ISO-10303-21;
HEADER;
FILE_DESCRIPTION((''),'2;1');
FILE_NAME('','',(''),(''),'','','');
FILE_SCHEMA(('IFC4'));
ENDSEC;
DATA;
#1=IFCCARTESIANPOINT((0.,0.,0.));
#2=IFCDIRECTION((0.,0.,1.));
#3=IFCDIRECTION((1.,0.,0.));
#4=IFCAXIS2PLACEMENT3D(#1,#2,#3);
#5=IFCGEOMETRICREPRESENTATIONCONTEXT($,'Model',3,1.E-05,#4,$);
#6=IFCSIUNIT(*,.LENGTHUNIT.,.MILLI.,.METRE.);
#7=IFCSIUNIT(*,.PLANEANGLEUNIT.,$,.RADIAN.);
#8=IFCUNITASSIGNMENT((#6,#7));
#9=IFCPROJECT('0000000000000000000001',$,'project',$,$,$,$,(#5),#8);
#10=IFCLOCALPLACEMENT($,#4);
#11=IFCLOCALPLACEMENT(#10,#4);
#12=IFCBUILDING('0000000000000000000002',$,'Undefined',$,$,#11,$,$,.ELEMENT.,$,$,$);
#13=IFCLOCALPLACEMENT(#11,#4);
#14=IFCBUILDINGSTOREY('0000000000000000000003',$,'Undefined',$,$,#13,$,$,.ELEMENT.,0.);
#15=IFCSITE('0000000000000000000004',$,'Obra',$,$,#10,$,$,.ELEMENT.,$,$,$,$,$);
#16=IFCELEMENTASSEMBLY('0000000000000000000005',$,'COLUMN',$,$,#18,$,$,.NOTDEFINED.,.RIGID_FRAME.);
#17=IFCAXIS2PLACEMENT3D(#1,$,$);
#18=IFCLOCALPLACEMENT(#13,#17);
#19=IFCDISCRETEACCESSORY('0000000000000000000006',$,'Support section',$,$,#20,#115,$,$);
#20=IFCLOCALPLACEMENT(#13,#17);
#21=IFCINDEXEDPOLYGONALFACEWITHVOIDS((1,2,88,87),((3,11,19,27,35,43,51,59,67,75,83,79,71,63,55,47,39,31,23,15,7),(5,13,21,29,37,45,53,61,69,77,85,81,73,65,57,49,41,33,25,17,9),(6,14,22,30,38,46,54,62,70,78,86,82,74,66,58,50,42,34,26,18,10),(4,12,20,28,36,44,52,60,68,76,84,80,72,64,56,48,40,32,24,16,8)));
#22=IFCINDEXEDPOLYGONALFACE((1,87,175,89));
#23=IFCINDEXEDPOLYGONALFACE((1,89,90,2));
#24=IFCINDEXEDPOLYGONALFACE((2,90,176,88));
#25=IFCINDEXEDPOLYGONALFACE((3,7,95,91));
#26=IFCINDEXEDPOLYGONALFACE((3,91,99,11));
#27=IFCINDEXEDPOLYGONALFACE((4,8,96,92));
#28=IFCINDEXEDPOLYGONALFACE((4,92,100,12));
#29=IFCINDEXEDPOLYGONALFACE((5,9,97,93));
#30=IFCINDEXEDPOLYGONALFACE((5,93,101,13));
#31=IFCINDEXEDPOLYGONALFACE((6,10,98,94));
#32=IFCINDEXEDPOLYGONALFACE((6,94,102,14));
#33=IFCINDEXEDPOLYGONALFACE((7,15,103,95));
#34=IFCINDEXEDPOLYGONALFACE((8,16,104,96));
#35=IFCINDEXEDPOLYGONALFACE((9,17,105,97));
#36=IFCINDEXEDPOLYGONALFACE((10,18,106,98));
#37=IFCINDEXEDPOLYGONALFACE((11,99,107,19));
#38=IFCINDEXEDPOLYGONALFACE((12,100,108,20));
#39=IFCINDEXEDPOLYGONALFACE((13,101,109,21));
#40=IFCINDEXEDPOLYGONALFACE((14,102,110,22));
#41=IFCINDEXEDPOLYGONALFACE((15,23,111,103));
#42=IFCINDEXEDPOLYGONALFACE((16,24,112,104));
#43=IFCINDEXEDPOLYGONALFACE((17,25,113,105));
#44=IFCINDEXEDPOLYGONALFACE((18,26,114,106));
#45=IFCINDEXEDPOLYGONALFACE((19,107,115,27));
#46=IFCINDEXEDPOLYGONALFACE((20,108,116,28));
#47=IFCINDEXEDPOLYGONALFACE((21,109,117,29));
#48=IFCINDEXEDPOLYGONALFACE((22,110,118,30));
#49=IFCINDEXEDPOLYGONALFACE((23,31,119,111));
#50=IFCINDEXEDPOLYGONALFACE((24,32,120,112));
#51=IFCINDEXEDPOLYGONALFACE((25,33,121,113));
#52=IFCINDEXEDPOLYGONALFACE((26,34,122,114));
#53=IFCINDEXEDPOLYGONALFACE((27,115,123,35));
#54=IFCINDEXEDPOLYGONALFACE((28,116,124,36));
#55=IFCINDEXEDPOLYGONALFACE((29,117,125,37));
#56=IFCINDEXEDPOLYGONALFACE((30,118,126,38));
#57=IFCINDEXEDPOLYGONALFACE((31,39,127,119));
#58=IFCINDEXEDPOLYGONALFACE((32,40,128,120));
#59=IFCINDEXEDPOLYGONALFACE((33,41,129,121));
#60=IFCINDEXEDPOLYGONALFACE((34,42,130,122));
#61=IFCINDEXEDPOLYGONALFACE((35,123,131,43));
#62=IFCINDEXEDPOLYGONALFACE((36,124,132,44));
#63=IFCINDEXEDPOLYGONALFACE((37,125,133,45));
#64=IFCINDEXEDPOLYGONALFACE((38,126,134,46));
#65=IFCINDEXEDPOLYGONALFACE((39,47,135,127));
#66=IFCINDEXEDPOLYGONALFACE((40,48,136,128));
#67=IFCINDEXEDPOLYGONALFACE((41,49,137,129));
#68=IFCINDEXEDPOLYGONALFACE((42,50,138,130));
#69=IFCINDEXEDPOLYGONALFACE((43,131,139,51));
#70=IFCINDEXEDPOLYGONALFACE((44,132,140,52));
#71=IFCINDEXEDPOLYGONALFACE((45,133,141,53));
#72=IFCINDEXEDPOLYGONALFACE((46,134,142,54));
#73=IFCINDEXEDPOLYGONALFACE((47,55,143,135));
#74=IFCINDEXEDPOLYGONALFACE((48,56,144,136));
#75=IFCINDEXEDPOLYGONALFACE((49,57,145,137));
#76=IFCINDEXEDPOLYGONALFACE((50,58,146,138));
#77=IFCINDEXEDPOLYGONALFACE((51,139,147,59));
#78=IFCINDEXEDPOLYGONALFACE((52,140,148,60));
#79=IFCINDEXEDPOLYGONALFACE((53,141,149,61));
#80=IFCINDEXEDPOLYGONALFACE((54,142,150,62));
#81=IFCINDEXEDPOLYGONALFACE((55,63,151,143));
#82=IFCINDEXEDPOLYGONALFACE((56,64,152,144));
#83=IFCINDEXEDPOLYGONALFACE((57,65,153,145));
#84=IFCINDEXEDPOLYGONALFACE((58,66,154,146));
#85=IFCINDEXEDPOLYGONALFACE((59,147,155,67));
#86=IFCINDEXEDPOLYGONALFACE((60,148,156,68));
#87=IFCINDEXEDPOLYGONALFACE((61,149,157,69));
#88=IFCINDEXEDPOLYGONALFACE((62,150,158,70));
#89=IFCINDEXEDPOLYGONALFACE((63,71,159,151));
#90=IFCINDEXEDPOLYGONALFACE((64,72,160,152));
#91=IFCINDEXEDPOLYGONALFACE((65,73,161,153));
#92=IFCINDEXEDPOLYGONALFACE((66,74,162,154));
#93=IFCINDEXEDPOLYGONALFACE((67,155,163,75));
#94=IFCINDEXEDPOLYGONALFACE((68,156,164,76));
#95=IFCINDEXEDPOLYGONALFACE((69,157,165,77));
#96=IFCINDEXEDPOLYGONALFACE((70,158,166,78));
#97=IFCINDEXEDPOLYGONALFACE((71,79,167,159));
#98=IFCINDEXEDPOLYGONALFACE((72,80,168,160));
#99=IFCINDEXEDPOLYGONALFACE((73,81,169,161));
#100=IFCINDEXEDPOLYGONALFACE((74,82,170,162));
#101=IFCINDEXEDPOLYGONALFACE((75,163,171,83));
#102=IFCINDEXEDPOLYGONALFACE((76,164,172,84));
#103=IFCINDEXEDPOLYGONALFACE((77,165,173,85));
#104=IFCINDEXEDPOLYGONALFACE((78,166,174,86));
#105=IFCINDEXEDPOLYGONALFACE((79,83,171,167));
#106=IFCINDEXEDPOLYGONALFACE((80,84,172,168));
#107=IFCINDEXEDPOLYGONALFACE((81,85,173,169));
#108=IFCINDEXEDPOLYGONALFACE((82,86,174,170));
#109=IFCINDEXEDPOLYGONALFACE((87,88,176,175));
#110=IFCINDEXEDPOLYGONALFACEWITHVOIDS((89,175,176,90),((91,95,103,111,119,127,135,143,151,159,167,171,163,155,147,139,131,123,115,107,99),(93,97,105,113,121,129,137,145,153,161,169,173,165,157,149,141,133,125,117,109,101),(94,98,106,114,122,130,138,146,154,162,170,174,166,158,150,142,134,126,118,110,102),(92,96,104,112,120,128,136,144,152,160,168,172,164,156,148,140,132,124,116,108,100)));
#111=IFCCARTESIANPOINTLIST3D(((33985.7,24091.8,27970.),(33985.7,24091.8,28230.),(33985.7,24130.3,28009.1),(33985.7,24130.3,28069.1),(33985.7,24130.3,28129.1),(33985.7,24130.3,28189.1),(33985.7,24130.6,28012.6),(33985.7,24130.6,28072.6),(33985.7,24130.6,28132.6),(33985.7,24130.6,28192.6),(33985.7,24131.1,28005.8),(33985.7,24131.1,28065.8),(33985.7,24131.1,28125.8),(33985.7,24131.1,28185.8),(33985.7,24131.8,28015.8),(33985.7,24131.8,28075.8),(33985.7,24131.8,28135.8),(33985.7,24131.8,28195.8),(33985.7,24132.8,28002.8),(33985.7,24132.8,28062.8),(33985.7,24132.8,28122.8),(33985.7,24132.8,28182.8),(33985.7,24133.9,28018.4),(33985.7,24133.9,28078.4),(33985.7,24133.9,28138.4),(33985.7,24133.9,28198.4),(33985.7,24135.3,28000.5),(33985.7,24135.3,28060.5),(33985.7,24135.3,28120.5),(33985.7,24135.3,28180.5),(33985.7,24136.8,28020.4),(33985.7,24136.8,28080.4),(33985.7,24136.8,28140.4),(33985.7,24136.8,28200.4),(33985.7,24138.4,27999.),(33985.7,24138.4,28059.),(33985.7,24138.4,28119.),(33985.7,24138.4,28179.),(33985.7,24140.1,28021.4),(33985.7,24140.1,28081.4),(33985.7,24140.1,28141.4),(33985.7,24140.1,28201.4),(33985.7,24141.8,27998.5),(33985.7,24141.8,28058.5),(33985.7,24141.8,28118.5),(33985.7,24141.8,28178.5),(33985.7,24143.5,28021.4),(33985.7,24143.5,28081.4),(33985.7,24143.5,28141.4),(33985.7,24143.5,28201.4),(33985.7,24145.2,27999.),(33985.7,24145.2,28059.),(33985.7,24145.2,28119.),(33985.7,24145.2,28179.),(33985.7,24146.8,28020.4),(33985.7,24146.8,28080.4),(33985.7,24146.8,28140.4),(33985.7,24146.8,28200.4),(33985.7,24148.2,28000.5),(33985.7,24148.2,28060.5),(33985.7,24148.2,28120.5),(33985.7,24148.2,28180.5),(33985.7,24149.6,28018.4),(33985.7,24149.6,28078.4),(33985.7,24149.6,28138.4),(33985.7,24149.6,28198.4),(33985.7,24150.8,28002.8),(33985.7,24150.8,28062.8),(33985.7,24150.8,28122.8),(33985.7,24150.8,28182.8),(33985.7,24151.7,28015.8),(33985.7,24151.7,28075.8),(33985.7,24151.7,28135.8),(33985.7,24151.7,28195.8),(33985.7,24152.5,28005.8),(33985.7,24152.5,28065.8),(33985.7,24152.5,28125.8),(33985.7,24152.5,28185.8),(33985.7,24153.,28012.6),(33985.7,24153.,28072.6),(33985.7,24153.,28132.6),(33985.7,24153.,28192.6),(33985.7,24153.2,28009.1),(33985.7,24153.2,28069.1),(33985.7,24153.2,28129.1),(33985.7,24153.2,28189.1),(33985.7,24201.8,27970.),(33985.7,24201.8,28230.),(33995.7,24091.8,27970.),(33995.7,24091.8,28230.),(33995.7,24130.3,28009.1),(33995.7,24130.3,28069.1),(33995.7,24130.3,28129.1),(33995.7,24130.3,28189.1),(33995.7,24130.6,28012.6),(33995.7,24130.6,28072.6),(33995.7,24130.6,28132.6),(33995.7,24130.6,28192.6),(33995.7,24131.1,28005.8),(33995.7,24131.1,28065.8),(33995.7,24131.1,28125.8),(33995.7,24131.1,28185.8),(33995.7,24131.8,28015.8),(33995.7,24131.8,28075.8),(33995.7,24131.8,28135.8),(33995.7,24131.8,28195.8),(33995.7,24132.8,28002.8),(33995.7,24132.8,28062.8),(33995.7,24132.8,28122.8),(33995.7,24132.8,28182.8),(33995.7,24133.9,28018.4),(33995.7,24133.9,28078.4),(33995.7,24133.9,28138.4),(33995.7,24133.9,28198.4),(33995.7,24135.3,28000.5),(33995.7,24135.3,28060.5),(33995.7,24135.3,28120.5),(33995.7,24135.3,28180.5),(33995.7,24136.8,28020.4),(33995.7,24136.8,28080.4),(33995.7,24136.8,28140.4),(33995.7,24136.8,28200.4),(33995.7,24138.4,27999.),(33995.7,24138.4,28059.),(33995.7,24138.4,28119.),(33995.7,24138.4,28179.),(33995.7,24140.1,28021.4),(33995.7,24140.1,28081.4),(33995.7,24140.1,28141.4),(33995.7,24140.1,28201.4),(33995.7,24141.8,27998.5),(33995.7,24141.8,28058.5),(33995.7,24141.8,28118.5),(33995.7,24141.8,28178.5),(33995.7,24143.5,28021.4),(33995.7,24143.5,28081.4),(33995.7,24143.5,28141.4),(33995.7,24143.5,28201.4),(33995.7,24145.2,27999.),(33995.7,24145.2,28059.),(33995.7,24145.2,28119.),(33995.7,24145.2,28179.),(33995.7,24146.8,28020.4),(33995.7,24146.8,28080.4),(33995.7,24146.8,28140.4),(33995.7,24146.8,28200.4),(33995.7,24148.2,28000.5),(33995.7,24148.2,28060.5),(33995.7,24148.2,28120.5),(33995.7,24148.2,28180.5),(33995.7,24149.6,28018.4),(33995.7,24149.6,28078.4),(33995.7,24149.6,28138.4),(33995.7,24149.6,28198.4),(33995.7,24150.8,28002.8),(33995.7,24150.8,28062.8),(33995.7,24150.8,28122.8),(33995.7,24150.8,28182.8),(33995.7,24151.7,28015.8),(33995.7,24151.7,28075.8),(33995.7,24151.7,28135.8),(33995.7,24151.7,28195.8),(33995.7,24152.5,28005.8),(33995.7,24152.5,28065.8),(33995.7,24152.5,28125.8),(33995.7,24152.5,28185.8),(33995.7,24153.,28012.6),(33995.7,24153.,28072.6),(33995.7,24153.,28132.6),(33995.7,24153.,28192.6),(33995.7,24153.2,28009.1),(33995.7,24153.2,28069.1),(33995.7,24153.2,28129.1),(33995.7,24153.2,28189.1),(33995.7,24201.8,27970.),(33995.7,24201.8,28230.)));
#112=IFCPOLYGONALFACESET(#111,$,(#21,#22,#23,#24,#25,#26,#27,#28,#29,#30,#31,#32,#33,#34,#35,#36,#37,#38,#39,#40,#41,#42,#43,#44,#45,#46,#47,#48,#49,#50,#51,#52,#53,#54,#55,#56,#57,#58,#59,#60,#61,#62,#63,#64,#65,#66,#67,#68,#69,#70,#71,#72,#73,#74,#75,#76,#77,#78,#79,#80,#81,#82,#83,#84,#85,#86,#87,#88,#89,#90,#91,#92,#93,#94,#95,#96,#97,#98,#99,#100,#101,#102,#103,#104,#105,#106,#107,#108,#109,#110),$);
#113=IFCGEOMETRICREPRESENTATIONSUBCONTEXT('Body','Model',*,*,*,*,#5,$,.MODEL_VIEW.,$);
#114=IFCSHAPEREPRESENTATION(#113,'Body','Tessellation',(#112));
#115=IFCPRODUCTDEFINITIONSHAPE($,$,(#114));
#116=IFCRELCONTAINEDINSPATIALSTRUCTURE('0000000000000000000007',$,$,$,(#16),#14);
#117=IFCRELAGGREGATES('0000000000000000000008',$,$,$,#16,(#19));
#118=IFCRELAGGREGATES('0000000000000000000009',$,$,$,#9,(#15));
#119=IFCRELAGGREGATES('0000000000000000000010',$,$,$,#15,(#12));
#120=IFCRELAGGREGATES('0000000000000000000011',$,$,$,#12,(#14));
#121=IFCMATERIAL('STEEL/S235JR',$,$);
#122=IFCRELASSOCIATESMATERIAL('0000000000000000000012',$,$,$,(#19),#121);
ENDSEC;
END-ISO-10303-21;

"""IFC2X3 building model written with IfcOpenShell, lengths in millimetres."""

from ifc_helpers import new_model, si_unit, frame, origin_with_axes, origin_2d_with_axis, place, context, subcontext, project, spatial, rectangle, circle, extrude, source, transform, mapped, material, element, aggregate, save


model = new_model("IFC2X3")

# Units and contexts
model_context = context("Model", 3, precision=1e-05, world=origin_with_axes())
body_context = subcontext(model_context, "Body", "Model", "MODEL_VIEW")
ifc_project = project(units=[si_unit("LENGTHUNIT", "METRE", prefix="MILLI"), si_unit("PLANEANGLEUNIT", "RADIAN")], contexts=[model_context])

# Site, building, storey
site_placement = place(None, origin_with_axes())
site = spatial("IfcSite", under=ifc_project, at=site_placement, Name="Obra", CompositionType="ELEMENT")
building_placement = place(site_placement, origin_with_axes())
building = spatial("IfcBuilding", under=site, at=building_placement, Name="Undefined", CompositionType="ELEMENT")
storey_placement = place(building_placement, origin_with_axes())
storey = spatial("IfcBuildingStorey", under=building, at=storey_placement, Name="Undefined", CompositionType="ELEMENT", Elevation=0.0)

# Shared definitions
ifc_material_1 = material(Name="STEEL/S235JR")

# Element assembly, discrete accessory, opening
assembly_1_placement = place(storey_placement, origin_with_axes())
assembly_1 = element("IfcElementAssembly", 1, at=assembly_1_placement, inside=storey, Name="COLUMN", AssemblyPlace="NOTDEFINED", PredefinedType="RIGID_FRAME")
shared_shape_1 = source(origin_with_axes(), body_context, "Body", "SweptSolid", [
    extrude(circle(Radius=11.5, at=origin_2d_with_axis()), frame((0.0, -14.4, 0.0), z_axis=(0.0, 1.0, 0.0), x_axis=(1.0, 0.0, 0.0)), (0.0, 0.0, 1.0), 10.2),
])
discrete_accessory_1_placement = place(assembly_1_placement, frame((33990.7, 24146.8, 27970.0), z_axis=(0.0, 0.0, 1.0), x_axis=(0.0, 1.0, 0.0)))
discrete_accessory_1 = element("IfcDiscreteAccessory", 2, at=discrete_accessory_1_placement, material=ifc_material_1, Name="Support section", context=body_context, shape_type="SweptSolid", body=[
    extrude(rectangle(XDim=10.0, YDim=110.0, at=origin_2d_with_axis()), frame((0.0, 0.0, 260.0), z_axis=(0.0, 0.0, -1.0), x_axis=(0.0, 1.0, 0.0)), (0.0, 0.0, 1.0), 260.0),
])
opening_1_placement = place(assembly_1_placement, frame((34000.0, 24191.8, 28300.0), z_axis=(0.0, -1.0, 0.0), x_axis=(0.0, 0.0, -1.0)))
element("IfcOpeningElement", 3, at=opening_1_placement, cuts=discrete_accessory_1, ObjectType="Opening", context=body_context, shape_type="MappedRepresentation", body=[
    mapped(shared_shape_1, transform((110.0, 0.0, 50.0))),
    mapped(shared_shape_1, transform((170.0, 0.0, 50.0))),
    mapped(shared_shape_1, transform((230.0, 0.0, 50.0))),
    mapped(shared_shape_1, transform((290.0, 0.0, 50.0))),
])
aggregate(assembly_1, [discrete_accessory_1])

save(model, "model.ifc")
